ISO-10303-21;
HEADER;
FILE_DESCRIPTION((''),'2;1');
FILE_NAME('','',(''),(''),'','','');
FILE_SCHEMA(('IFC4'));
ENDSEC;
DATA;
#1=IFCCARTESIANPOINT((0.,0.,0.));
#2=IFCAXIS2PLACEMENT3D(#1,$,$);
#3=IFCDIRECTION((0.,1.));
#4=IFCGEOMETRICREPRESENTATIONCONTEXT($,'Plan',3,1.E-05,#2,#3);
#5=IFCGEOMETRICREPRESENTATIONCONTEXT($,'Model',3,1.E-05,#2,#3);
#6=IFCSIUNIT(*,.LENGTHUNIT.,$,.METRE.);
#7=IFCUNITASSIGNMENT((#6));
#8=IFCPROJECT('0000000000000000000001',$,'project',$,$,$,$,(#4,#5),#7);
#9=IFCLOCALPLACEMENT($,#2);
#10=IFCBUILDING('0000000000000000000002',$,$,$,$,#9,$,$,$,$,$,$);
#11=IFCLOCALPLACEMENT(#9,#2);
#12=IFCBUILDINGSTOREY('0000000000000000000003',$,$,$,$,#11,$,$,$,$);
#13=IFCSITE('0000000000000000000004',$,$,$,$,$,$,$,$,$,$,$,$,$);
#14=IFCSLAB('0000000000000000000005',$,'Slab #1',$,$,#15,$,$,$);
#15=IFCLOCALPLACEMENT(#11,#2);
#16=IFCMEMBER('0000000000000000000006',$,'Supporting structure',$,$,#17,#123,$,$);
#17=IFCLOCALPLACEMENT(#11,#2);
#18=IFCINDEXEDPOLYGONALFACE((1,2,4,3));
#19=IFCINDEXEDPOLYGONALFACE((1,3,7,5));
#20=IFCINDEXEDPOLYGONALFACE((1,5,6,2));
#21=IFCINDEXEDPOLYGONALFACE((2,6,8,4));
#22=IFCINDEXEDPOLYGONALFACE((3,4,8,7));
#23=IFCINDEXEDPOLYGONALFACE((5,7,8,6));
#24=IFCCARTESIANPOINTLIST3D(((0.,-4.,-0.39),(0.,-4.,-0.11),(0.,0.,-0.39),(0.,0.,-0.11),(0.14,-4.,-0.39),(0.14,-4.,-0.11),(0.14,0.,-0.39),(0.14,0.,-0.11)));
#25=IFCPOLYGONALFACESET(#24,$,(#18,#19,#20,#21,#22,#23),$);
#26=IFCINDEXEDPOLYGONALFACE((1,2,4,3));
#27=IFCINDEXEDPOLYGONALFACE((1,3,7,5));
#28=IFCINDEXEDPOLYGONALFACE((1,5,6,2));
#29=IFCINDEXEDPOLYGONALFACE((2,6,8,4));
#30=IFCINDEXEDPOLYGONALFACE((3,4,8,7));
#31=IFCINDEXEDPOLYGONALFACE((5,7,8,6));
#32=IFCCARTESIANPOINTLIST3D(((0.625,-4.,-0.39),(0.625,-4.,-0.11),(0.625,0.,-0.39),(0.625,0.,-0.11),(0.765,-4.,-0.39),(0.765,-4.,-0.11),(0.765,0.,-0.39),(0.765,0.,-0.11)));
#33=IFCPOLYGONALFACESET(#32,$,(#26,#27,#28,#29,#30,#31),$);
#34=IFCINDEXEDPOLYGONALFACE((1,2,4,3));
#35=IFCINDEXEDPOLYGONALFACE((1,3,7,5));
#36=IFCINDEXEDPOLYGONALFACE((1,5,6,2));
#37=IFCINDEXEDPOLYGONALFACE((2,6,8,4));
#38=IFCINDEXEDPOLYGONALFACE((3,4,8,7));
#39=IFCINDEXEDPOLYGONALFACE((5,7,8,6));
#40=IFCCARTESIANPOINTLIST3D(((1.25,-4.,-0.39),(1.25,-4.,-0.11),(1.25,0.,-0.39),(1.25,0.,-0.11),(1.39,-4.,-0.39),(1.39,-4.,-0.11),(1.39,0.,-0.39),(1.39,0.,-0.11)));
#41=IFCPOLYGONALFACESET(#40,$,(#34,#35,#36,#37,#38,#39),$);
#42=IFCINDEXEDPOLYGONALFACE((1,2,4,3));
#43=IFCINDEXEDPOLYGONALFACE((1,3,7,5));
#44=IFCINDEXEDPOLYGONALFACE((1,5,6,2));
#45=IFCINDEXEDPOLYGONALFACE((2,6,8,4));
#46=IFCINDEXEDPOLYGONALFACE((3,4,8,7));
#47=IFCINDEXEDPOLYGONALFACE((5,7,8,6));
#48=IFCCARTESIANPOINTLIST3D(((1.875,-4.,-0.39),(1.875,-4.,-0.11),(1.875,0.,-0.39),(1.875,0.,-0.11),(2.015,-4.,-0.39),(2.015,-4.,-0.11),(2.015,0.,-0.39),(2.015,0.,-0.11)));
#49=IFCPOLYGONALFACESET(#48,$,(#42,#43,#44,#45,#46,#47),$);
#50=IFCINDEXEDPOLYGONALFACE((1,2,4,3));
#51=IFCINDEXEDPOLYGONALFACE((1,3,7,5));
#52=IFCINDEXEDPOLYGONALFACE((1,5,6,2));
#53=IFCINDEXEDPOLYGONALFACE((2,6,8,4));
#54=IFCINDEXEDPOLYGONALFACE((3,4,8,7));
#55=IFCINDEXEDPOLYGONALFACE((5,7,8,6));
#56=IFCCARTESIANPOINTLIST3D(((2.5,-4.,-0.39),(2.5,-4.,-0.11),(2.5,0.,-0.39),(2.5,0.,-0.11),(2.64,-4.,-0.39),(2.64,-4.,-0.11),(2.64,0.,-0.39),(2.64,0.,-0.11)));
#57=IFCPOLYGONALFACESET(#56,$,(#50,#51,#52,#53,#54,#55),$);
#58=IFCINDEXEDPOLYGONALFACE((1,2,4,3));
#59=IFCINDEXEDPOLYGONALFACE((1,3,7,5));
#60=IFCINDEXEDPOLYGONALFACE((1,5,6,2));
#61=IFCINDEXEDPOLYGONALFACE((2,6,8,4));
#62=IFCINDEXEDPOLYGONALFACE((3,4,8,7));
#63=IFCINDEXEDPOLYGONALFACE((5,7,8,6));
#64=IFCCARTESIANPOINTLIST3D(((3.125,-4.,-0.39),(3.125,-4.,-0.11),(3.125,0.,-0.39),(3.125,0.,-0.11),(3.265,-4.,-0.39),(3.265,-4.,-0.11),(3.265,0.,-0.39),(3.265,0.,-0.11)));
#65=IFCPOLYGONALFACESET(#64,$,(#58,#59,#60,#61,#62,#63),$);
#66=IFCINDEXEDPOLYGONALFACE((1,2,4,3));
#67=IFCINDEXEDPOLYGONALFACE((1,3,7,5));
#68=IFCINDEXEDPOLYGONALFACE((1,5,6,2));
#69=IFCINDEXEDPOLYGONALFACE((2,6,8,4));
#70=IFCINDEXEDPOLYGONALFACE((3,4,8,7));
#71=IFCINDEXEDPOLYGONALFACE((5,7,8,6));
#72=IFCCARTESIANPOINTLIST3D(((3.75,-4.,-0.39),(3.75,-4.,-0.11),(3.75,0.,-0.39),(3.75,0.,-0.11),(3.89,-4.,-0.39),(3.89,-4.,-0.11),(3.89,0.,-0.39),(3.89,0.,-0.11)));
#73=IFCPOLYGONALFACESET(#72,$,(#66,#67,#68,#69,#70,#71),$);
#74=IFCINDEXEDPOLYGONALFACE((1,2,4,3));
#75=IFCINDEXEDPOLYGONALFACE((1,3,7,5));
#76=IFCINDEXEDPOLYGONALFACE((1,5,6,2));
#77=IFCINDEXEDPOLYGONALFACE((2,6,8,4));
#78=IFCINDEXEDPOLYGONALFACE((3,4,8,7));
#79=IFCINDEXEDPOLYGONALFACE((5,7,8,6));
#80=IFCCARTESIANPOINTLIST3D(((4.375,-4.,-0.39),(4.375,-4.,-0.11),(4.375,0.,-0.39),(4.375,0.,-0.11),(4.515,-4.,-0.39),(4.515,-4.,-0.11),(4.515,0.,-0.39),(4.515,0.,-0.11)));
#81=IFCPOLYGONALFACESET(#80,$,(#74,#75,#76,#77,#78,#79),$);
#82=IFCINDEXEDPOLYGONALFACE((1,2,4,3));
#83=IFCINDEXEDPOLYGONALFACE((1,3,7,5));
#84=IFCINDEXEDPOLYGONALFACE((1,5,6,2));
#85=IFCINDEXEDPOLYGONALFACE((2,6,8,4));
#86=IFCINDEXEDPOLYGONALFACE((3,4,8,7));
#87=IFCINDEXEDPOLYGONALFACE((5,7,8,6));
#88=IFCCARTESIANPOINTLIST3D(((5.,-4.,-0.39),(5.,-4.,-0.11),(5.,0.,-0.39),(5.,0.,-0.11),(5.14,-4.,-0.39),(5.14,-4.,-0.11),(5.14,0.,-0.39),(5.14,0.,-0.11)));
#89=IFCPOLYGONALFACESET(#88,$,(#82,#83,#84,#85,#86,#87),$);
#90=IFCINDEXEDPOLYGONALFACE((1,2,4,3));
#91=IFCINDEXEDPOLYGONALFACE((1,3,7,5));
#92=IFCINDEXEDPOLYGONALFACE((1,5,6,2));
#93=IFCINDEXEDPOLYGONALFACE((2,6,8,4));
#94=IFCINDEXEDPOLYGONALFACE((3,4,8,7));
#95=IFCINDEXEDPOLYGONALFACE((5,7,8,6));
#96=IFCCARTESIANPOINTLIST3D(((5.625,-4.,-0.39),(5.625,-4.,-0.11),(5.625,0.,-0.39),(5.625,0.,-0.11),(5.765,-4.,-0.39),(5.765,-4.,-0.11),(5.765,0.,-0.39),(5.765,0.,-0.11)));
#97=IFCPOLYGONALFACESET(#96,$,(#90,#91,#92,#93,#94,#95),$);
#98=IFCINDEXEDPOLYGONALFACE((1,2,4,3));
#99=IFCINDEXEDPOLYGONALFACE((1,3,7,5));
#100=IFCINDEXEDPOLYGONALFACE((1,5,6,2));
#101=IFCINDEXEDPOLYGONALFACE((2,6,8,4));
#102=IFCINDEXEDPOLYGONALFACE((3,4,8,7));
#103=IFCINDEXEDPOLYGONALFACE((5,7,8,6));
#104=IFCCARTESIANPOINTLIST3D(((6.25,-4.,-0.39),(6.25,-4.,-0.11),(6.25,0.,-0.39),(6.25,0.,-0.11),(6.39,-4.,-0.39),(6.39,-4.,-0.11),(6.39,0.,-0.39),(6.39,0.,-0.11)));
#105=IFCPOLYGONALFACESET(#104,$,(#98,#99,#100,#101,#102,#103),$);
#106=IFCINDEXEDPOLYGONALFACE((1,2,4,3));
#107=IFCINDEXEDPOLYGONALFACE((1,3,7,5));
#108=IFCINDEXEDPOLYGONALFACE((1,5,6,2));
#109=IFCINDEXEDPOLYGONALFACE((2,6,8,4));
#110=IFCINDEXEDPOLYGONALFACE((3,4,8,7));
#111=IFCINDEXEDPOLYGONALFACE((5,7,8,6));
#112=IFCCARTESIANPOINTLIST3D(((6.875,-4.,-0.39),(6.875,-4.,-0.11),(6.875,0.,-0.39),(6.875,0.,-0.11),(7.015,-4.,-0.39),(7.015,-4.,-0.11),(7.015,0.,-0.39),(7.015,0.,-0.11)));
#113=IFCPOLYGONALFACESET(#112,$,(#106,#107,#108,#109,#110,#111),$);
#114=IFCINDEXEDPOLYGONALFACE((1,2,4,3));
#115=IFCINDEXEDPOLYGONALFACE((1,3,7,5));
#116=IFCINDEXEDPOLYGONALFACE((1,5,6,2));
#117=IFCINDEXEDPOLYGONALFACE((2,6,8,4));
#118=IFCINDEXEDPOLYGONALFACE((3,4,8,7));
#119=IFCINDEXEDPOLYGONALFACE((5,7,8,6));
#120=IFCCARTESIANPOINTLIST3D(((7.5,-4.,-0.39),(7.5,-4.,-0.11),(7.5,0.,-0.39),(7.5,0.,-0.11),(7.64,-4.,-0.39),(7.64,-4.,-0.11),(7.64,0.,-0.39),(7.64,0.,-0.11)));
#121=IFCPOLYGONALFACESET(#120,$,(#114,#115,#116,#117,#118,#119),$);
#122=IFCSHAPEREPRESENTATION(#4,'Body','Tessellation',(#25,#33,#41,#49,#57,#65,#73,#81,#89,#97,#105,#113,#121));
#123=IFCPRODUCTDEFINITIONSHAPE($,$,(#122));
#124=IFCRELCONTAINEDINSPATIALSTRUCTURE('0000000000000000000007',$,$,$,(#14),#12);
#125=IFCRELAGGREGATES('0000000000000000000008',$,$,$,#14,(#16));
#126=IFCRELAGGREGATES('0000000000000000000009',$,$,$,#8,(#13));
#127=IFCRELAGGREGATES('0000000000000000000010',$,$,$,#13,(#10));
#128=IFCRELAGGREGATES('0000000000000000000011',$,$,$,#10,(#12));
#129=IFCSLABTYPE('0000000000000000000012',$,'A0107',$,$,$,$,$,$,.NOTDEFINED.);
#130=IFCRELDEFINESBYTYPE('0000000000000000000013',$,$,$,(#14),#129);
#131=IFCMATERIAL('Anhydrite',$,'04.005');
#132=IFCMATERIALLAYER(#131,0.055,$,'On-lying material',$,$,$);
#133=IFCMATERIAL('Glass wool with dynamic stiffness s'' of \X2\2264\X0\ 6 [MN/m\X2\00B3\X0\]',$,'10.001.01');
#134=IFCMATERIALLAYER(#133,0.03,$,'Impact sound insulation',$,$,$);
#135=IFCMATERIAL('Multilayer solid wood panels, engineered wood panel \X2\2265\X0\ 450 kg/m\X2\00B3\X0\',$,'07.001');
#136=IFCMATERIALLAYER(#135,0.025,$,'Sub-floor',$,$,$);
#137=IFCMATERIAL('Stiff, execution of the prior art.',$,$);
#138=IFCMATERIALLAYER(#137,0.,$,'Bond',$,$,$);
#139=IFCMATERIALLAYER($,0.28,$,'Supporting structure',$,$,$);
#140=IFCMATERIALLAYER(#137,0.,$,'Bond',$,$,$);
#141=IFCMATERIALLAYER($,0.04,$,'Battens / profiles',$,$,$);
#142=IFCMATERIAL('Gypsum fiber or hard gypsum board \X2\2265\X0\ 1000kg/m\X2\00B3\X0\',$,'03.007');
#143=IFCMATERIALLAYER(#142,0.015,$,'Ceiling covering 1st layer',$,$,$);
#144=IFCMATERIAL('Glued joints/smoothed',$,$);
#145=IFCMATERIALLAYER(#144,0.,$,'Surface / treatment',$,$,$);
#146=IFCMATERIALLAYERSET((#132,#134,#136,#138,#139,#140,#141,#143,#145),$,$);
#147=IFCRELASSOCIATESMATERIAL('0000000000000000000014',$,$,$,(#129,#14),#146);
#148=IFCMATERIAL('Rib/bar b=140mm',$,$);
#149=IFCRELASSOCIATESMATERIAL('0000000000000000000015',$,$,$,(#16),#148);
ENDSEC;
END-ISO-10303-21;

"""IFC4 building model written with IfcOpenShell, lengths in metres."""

from ifc_helpers import new_model, si_unit, direction, frame, frame_2d, origin, place, context, project, spatial, rectangle, extrude, material, layer, layer_set, type_object, element, aggregate, save


model = new_model("IFC4")

# Units and contexts
plan_context = context("Plan", 3, precision=1e-05, world=origin(), true_north=direction((0.0, 1.0)))
model_context = context("Model", 3, precision=1e-05, world=origin(), true_north=direction((0.0, 1.0)))
ifc_project = project(units=[si_unit("LENGTHUNIT", "METRE")], contexts=[plan_context, model_context])

# Site, building, storey
site = spatial("IfcSite", under=ifc_project)
building_placement = place(None, origin())
building = spatial("IfcBuilding", under=site, at=building_placement)
storey_placement = place(building_placement, origin())
storey = spatial("IfcBuildingStorey", under=building, at=storey_placement)

# Slab, member
ifc_material_1 = material(Name="Anhydrite", Category="04.005")
ifc_layer_1 = layer(ifc_material_1, 0.055, Name="On-lying material")
ifc_material_2 = material(Name="Glass wool with dynamic stiffness s' of ≤ 6 [MN/m³]", Category="10.001.01")
ifc_layer_2 = layer(ifc_material_2, 0.03, Name="Impact sound insulation")
ifc_material_3 = material(Name="Multilayer solid wood panels, engineered wood panel ≥ 450 kg/m³", Category="07.001")
ifc_layer_3 = layer(ifc_material_3, 0.025, Name="Sub-floor")
ifc_material_4 = material(Name="Stiff, execution of the prior art.")
ifc_layer_4 = layer(ifc_material_4, 0.0, Name="Bond")
ifc_layer_5 = layer(None, 0.28, Name="Supporting structure")
ifc_layer_6 = layer(ifc_material_4, 0.0, Name="Bond")
ifc_layer_7 = layer(None, 0.04, Name="Battens / profiles")
ifc_material_5 = material(Name="Gypsum fiber or hard gypsum board ≥ 1000kg/m³", Category="03.007")
ifc_layer_8 = layer(ifc_material_5, 0.015, Name="Ceiling covering 1st layer")
ifc_material_6 = material(Name="Glued joints/smoothed")
ifc_layer_9 = layer(ifc_material_6, 0.0, Name="Surface / treatment")
ifc_layer_set = layer_set([ifc_layer_1, ifc_layer_2, ifc_layer_3, ifc_layer_4, ifc_layer_5, ifc_layer_6, ifc_layer_7, ifc_layer_8, ifc_layer_9])
slab_type = type_object("IfcSlabType", Name="A0107", PredefinedType="NOTDEFINED", material=ifc_layer_set)
slab_placement = place(None, frame((0.0, 0.0, 0.0), z_axis=(0.0, 0.0, -1.0), x_axis=(1.0, 0.0, 0.0)))
slab = element("IfcSlab", 1, at=slab_placement, inside=storey, type_object=slab_type, material=ifc_layer_set, Name="Slab #1")
ifc_material_7 = material(Name="Rib/bar b=140mm")
member_1_placement = place(slab_placement, origin())
member_1 = element("IfcMember", 2, at=member_1_placement, material=ifc_material_7, Name="Supporting structure", context=plan_context, shape_type="SweptSolid", body=[
    extrude(rectangle(XDim=0.14, YDim=0.28, at=frame_2d((0.07, 0.14), x_axis=(1.0, 0.0))), frame((0.0, 4.0, 0.11), z_axis=(0.0, -1.0, 0.0), x_axis=(1.0, 0.0, 0.0)), (0.0, 0.0, 1.0), 4.0),
    extrude(rectangle(XDim=0.14, YDim=0.28, at=frame_2d((0.07, 0.14), x_axis=(1.0, 0.0))), frame((0.625, 4.0, 0.11), z_axis=(0.0, -1.0, 0.0), x_axis=(1.0, 0.0, 0.0)), (0.0, 0.0, 1.0), 4.0),
    extrude(rectangle(XDim=0.14, YDim=0.28, at=frame_2d((0.07, 0.14), x_axis=(1.0, 0.0))), frame((1.25, 4.0, 0.11), z_axis=(0.0, -1.0, 0.0), x_axis=(1.0, 0.0, 0.0)), (0.0, 0.0, 1.0), 4.0),
    extrude(rectangle(XDim=0.14, YDim=0.28, at=frame_2d((0.07, 0.14), x_axis=(1.0, 0.0))), frame((1.875, 4.0, 0.11), z_axis=(0.0, -1.0, 0.0), x_axis=(1.0, 0.0, 0.0)), (0.0, 0.0, 1.0), 4.0),
    extrude(rectangle(XDim=0.14, YDim=0.28, at=frame_2d((0.07, 0.14), x_axis=(1.0, 0.0))), frame((2.5, 4.0, 0.11), z_axis=(0.0, -1.0, 0.0), x_axis=(1.0, 0.0, 0.0)), (0.0, 0.0, 1.0), 4.0),
    extrude(rectangle(XDim=0.14, YDim=0.28, at=frame_2d((0.07, 0.14), x_axis=(1.0, 0.0))), frame((3.125, 4.0, 0.11), z_axis=(0.0, -1.0, 0.0), x_axis=(1.0, 0.0, 0.0)), (0.0, 0.0, 1.0), 4.0),
    extrude(rectangle(XDim=0.14, YDim=0.28, at=frame_2d((0.07, 0.14), x_axis=(1.0, 0.0))), frame((3.75, 4.0, 0.11), z_axis=(0.0, -1.0, 0.0), x_axis=(1.0, 0.0, 0.0)), (0.0, 0.0, 1.0), 4.0),
    extrude(rectangle(XDim=0.14, YDim=0.28, at=frame_2d((0.07, 0.14), x_axis=(1.0, 0.0))), frame((4.375, 4.0, 0.11), z_axis=(0.0, -1.0, 0.0), x_axis=(1.0, 0.0, 0.0)), (0.0, 0.0, 1.0), 4.0),
    extrude(rectangle(XDim=0.14, YDim=0.28, at=frame_2d((0.07, 0.14), x_axis=(1.0, 0.0))), frame((5.0, 4.0, 0.11), z_axis=(0.0, -1.0, 0.0), x_axis=(1.0, 0.0, 0.0)), (0.0, 0.0, 1.0), 4.0),
    extrude(rectangle(XDim=0.14, YDim=0.28, at=frame_2d((0.07, 0.14), x_axis=(1.0, 0.0))), frame((5.625, 4.0, 0.11), z_axis=(0.0, -1.0, 0.0), x_axis=(1.0, 0.0, 0.0)), (0.0, 0.0, 1.0), 4.0),
    extrude(rectangle(XDim=0.14, YDim=0.28, at=frame_2d((0.07, 0.14), x_axis=(1.0, 0.0))), frame((6.25, 4.0, 0.11), z_axis=(0.0, -1.0, 0.0), x_axis=(1.0, 0.0, 0.0)), (0.0, 0.0, 1.0), 4.0),
    extrude(rectangle(XDim=0.14, YDim=0.28, at=frame_2d((0.07, 0.14), x_axis=(1.0, 0.0))), frame((6.875, 4.0, 0.11), z_axis=(0.0, -1.0, 0.0), x_axis=(1.0, 0.0, 0.0)), (0.0, 0.0, 1.0), 4.0),
    extrude(rectangle(XDim=0.14, YDim=0.28, at=frame_2d((0.07, 0.14), x_axis=(1.0, 0.0))), frame((7.5, 4.0, 0.11), z_axis=(0.0, -1.0, 0.0), x_axis=(1.0, 0.0, 0.0)), (0.0, 0.0, 1.0), 4.0),
])
aggregate(slab, [member_1])

save(model, "model.ifc")
